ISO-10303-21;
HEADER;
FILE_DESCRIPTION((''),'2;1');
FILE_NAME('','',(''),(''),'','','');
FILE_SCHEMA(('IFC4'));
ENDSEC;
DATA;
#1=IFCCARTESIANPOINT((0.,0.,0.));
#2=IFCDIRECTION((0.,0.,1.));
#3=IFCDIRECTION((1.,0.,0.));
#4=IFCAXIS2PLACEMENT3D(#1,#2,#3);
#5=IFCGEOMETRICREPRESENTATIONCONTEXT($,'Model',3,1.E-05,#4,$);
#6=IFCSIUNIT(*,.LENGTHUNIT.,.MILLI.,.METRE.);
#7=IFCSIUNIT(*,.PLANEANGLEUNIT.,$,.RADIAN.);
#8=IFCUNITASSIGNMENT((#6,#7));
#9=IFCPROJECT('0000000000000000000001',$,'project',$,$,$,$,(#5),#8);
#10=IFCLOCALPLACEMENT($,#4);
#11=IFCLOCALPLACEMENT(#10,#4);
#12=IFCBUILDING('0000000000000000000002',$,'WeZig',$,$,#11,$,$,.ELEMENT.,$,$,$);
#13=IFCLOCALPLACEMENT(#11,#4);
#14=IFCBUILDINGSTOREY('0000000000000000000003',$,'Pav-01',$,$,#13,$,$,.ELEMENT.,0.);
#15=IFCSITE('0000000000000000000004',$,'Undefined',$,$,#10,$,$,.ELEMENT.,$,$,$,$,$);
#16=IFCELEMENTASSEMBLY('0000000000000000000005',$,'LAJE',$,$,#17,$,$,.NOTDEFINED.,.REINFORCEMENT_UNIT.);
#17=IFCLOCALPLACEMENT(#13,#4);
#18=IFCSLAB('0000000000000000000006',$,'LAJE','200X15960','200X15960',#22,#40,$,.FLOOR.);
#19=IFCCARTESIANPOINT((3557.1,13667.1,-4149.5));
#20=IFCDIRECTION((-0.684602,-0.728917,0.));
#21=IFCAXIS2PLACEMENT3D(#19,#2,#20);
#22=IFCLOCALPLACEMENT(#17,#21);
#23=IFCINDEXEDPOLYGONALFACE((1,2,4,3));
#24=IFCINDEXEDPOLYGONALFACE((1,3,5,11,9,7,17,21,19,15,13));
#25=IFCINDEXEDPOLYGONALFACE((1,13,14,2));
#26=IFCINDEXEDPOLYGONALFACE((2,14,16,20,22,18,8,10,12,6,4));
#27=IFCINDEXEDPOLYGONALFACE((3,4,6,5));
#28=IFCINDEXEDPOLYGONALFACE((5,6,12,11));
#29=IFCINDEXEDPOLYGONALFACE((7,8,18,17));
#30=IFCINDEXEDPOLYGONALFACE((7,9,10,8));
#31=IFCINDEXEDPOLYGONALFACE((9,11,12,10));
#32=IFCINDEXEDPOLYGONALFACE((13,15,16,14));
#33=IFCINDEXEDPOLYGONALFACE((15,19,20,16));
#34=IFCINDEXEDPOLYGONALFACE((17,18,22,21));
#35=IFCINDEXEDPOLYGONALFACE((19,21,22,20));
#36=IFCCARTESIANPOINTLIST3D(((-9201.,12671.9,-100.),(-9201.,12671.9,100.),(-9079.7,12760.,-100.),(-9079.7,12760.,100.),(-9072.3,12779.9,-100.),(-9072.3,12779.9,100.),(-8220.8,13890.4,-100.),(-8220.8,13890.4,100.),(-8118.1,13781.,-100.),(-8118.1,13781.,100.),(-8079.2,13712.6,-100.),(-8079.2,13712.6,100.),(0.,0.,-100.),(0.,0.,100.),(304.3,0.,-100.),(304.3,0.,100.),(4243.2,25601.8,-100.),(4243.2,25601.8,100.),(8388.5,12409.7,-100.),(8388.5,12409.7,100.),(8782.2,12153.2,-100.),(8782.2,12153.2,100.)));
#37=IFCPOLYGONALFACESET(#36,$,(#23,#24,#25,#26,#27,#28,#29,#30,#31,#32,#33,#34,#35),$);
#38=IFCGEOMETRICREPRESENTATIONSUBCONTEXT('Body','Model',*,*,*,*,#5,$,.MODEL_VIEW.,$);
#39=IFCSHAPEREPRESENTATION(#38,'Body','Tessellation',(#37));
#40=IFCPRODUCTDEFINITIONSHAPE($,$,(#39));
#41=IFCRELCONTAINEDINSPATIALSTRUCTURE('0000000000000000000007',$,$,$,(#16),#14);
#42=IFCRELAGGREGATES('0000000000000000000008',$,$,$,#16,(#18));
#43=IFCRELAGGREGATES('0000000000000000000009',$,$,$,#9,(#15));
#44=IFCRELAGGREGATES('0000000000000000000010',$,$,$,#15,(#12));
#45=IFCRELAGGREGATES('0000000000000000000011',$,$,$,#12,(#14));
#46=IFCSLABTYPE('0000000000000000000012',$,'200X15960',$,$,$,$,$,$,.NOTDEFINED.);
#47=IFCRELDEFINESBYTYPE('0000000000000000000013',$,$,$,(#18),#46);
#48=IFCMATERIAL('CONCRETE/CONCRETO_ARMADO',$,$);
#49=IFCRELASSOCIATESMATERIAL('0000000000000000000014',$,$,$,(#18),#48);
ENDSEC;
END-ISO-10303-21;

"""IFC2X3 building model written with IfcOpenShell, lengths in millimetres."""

from ifc_helpers import new_model, si_unit, frame, origin_with_axes, place, context, subcontext, project, spatial, polyline, outline, extrude, material, type_object, element, aggregate, save


model = new_model("IFC2X3")

# Units and contexts
model_context = context("Model", 3, precision=1e-05, world=origin_with_axes())
body_context = subcontext(model_context, "Body", "Model", "MODEL_VIEW")
ifc_project = project(units=[si_unit("LENGTHUNIT", "METRE", prefix="MILLI"), si_unit("PLANEANGLEUNIT", "RADIAN")], contexts=[model_context])

# Site, building, storey
site_placement = place(None, origin_with_axes())
site = spatial("IfcSite", under=ifc_project, at=site_placement, Name="Undefined", CompositionType="ELEMENT")
building_placement = place(site_placement, origin_with_axes())
building = spatial("IfcBuilding", under=site, at=building_placement, Name="WeZig", CompositionType="ELEMENT")
storey_placement = place(building_placement, origin_with_axes())
storey = spatial("IfcBuildingStorey", under=building, at=storey_placement, Name="Pav-01", CompositionType="ELEMENT", Elevation=0.0)

# Shared definitions
ifc_material_1 = material(Name="CONCRETE/CONCRETO_ARMADO")

# Element assembly, slab
assembly_1_placement = place(storey_placement, origin_with_axes())
assembly_1 = element("IfcElementAssembly", 1, at=assembly_1_placement, inside=storey, Name="LAJE", AssemblyPlace="NOTDEFINED", PredefinedType="REINFORCEMENT_UNIT")
slab_type = type_object("IfcSlabType", Name="200X15960", PredefinedType="NOTDEFINED")
slab_placement = place(assembly_1_placement, frame((3557.1, 13667.1, -4149.5), z_axis=(0.0, 0.0, 1.0), x_axis=(-0.684602, -0.728917, 0.0)))
slab = element("IfcSlab", 2, at=slab_placement, type_object=slab_type, material=ifc_material_1, Name="LAJE", Description="200X15960", ObjectType="200X15960", PredefinedType="FLOOR", context=body_context, shape_type="SweptSolid", body=[
    extrude(outline(polyline([(0.0, 0.0), (304.3, 0.0), (8388.5, 12409.7), (8782.2, 12153.2), (4243.2, 25601.8), (-8220.8, 13890.4), (-8118.1, 13781.0), (-8079.2, 13712.6), (-9072.3, 12779.9), (-9079.7, 12760.0), (-9201.0, 12671.9), (0.0, 0.0)])), frame((0.0, 0.0, -100.0), z_axis=(0.0, 0.0, 1.0), x_axis=(1.0, 0.0, 0.0)), (0.0, 0.0, 1.0), 200.0),
])
aggregate(assembly_1, [slab])

save(model, "model.ifc")
